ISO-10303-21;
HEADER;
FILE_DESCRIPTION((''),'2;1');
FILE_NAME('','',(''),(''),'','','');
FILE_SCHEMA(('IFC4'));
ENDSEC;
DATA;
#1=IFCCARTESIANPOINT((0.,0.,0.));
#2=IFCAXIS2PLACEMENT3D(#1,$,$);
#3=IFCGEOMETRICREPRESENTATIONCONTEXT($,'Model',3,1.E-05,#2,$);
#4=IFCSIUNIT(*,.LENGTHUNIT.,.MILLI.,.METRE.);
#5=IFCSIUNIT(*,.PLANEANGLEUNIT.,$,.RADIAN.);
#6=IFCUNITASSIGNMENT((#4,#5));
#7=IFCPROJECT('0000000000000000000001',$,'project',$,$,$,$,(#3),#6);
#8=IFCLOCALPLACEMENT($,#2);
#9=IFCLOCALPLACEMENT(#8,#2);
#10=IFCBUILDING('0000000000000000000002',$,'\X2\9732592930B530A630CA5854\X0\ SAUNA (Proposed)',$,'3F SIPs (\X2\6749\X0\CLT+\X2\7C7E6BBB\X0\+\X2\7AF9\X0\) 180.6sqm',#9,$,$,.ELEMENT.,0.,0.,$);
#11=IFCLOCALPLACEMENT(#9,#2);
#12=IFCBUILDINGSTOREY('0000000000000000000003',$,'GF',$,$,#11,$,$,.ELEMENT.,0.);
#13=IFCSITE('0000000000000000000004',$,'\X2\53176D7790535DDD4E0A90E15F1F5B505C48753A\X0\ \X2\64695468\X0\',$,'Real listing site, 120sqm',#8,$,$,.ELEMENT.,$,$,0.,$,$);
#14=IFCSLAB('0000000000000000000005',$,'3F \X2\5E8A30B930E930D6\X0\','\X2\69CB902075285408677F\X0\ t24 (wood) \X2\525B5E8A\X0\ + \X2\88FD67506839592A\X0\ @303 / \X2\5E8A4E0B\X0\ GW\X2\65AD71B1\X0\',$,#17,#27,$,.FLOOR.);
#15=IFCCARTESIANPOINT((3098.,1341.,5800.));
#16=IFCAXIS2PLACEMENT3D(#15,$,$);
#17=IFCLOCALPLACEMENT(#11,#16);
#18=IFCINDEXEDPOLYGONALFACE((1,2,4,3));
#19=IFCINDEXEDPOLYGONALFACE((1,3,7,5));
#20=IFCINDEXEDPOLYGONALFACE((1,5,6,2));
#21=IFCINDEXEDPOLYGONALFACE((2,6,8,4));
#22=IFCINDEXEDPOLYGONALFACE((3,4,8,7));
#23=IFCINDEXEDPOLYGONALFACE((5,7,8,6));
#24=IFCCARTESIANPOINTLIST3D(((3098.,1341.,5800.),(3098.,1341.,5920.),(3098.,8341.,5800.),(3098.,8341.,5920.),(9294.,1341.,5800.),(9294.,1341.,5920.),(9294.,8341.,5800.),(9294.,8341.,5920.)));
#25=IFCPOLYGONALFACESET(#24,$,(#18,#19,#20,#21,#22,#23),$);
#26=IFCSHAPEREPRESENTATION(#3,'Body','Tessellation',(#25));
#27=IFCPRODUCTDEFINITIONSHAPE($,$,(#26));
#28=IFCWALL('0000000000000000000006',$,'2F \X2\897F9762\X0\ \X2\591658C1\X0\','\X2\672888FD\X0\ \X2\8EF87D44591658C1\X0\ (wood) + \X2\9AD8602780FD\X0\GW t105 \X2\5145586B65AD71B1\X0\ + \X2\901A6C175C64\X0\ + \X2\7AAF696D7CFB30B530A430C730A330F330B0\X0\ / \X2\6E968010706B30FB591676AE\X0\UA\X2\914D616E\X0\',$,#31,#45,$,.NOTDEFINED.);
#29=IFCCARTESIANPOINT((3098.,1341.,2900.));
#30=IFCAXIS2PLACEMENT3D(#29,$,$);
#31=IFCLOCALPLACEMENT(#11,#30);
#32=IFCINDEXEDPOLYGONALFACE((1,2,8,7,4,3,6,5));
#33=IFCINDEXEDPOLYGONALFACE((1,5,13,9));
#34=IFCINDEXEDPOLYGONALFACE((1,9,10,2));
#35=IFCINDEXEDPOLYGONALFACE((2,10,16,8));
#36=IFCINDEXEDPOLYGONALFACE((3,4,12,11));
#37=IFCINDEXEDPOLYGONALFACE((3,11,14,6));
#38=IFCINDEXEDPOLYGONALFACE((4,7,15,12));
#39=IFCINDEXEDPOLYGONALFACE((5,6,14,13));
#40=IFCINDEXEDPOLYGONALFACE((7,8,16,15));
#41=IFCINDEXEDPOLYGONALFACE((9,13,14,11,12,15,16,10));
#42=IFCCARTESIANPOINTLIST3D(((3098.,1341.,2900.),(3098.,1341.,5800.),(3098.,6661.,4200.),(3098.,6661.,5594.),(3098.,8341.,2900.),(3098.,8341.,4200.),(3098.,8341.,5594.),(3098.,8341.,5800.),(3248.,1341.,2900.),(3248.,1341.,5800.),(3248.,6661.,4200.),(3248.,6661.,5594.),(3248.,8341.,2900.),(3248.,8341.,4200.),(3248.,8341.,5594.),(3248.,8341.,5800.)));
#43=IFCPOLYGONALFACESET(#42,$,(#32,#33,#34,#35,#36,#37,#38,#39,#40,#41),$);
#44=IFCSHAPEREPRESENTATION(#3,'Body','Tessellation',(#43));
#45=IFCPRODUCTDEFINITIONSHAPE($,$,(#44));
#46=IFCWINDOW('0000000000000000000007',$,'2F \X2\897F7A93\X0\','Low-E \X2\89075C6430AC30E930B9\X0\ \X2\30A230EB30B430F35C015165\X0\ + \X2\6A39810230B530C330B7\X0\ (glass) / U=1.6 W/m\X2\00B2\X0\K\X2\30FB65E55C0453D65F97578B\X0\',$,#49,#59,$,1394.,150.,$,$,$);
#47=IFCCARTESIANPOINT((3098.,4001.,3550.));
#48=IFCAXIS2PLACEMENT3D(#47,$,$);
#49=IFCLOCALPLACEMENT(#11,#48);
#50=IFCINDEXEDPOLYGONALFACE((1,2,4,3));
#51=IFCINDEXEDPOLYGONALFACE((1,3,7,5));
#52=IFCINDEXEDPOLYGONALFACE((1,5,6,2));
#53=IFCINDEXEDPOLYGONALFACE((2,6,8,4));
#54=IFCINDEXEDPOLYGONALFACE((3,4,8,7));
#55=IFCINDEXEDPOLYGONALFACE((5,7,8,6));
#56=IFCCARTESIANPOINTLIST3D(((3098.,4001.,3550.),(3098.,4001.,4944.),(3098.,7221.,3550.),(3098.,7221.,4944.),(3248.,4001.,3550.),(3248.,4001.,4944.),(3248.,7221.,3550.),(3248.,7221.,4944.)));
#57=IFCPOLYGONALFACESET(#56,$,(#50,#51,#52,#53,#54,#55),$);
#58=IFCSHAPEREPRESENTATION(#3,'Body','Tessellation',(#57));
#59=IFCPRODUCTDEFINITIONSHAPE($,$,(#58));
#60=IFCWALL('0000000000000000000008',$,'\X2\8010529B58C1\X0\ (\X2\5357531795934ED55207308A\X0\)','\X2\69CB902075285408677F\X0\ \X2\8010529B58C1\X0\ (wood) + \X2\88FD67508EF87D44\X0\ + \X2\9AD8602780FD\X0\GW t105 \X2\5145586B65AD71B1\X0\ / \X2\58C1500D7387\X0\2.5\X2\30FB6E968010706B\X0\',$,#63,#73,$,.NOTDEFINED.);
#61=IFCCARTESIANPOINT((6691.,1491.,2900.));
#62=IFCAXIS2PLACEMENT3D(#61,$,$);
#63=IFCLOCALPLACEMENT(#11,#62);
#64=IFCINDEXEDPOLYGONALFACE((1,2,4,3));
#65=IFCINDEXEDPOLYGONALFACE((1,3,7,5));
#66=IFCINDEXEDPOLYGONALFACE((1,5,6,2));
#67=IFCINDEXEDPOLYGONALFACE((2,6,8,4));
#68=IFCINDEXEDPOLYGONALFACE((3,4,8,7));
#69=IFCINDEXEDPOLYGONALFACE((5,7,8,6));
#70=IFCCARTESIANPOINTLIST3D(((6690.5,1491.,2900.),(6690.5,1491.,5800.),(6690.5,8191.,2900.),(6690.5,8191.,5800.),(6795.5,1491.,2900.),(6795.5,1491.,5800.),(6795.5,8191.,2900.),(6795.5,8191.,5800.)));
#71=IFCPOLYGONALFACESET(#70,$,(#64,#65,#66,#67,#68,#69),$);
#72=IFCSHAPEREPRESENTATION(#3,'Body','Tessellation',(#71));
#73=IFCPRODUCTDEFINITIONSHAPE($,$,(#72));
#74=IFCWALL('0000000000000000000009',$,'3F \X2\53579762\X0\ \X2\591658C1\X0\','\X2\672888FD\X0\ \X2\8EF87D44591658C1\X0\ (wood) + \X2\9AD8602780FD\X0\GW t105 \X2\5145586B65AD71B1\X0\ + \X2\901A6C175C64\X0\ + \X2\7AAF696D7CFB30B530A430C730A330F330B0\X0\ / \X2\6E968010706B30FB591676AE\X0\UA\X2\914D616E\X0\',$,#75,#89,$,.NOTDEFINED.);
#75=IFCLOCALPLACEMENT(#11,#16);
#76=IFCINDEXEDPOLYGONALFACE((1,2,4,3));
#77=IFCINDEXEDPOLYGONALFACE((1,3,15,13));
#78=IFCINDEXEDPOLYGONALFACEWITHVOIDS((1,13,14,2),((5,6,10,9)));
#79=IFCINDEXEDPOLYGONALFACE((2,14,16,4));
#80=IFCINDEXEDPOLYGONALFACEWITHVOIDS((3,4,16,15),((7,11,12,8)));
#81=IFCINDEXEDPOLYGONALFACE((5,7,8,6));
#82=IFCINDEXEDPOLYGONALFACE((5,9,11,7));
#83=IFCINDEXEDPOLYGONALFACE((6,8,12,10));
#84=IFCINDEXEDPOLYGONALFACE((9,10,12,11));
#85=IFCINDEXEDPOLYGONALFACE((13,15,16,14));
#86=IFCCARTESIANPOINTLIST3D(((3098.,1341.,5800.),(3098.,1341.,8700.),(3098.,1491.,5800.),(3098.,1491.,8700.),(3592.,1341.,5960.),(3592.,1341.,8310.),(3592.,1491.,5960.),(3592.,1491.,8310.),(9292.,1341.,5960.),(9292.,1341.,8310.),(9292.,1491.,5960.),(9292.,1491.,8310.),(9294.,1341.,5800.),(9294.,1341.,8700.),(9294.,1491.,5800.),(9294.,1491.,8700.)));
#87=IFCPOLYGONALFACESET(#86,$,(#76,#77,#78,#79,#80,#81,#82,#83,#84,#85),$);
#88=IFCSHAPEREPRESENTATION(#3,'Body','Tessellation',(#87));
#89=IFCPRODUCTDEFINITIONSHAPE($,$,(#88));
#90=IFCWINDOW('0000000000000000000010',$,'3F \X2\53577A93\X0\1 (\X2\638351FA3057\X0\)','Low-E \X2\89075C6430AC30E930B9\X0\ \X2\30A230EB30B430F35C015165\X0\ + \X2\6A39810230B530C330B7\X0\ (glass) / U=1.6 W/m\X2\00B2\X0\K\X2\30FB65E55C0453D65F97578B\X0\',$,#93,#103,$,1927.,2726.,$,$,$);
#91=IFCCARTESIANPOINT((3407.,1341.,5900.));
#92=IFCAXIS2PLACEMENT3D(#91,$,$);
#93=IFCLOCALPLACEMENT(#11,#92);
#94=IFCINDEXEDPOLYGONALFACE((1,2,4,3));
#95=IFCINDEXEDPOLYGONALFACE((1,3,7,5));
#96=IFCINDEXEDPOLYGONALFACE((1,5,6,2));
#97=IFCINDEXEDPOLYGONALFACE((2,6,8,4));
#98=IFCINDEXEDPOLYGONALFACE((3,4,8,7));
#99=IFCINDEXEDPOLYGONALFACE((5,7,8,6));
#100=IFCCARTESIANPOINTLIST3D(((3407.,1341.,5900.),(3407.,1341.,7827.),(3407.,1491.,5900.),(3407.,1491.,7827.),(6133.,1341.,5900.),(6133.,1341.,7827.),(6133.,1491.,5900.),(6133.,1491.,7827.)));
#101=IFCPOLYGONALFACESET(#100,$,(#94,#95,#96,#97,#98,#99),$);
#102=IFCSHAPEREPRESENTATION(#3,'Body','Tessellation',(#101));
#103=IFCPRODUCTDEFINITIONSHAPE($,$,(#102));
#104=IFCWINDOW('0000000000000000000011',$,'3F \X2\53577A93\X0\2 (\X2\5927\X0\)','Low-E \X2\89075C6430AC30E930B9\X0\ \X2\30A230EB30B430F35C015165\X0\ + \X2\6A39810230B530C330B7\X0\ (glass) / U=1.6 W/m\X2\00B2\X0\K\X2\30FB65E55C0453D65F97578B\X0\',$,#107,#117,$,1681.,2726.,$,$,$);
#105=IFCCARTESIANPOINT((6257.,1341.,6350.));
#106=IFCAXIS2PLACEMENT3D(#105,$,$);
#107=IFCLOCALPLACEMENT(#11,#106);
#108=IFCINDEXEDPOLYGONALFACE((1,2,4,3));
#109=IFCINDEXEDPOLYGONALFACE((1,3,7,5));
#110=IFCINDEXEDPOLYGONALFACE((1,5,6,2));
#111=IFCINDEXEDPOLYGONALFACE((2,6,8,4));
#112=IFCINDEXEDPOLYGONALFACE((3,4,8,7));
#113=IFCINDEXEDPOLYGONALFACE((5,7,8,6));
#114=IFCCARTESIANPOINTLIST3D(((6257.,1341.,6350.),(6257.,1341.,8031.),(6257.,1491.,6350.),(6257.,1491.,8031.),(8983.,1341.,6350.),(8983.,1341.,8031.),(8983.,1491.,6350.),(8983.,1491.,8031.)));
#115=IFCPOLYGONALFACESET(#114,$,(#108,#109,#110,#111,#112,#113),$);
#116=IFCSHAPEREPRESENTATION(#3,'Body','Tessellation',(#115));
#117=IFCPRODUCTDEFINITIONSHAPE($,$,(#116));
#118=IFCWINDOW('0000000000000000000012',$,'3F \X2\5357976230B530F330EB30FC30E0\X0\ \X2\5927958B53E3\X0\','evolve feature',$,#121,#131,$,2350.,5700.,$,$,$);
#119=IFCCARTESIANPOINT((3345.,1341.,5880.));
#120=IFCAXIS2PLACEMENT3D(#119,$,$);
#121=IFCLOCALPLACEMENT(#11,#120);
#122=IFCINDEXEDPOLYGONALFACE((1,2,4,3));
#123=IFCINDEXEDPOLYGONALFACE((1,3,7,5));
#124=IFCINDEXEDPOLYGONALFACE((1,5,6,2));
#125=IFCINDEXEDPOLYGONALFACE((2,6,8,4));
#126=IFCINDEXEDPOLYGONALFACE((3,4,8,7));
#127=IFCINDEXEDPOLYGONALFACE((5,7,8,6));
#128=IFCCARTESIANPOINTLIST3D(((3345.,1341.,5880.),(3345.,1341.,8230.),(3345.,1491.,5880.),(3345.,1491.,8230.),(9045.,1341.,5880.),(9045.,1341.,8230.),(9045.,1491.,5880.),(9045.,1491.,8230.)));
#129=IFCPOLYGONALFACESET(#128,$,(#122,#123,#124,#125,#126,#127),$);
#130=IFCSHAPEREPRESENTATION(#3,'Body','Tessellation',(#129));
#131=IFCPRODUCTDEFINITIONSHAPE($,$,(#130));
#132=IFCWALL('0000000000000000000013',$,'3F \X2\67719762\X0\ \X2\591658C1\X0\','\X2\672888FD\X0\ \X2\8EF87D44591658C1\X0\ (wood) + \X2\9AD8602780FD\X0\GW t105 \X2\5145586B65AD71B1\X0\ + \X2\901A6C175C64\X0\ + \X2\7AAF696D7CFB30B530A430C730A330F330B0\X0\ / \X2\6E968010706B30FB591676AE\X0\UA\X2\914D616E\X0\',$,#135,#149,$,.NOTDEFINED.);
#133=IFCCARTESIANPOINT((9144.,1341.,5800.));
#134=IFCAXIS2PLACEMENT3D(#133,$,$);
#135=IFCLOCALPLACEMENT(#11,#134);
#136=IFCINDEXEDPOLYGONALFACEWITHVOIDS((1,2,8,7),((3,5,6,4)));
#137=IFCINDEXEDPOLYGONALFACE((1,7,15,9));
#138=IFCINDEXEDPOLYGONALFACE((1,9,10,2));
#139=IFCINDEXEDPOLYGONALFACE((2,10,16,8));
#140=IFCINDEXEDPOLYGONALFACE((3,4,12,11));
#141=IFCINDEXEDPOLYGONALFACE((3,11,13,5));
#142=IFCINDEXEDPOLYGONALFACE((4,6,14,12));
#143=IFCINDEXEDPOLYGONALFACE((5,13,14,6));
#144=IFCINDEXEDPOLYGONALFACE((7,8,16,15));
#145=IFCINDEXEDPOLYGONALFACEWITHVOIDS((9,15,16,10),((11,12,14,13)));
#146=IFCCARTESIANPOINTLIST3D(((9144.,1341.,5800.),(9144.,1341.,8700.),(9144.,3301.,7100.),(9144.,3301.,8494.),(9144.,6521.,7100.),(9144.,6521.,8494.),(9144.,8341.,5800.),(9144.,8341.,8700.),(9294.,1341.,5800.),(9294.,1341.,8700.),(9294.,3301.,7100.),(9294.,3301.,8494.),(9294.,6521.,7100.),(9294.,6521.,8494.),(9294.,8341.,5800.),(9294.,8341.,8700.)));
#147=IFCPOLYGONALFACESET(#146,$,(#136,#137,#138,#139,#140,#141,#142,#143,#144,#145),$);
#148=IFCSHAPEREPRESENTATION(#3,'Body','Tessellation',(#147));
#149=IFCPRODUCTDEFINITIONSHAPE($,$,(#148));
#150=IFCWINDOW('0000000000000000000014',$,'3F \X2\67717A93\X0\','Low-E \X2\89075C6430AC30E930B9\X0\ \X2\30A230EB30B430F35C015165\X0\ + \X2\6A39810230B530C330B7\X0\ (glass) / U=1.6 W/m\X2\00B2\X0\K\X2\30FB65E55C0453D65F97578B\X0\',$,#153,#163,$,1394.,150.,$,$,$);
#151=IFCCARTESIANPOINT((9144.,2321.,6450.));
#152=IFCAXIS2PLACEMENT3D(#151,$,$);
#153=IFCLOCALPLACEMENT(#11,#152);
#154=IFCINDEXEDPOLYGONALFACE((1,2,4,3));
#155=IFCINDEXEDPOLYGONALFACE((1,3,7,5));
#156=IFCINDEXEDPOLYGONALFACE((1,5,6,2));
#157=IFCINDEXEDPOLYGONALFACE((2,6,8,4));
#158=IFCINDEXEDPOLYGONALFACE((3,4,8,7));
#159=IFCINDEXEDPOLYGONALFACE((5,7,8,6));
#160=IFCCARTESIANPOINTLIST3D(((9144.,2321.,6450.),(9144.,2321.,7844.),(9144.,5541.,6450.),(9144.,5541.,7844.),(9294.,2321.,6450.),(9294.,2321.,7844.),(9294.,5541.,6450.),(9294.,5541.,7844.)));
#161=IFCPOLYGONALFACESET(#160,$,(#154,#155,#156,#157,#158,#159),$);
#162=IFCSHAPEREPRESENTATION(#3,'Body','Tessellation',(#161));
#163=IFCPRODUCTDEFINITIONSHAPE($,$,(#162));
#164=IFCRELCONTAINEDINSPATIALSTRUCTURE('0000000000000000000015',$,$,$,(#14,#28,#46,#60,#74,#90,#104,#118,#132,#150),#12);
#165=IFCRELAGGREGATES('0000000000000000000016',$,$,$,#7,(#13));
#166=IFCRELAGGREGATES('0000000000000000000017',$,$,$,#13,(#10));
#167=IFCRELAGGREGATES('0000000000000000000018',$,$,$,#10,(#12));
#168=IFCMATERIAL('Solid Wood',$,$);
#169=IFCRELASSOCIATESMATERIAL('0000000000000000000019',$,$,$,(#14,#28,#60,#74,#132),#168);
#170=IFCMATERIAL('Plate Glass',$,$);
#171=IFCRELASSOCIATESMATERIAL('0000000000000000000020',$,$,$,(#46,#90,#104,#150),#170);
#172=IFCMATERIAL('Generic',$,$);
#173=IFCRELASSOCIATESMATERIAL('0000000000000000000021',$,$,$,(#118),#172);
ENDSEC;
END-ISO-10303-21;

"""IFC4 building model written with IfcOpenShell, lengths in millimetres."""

from ifc_helpers import new_model, si_unit, frame, frame_2d, origin, place, context, project, spatial, rectangle, extrude, material, element, fill, save


model = new_model("IFC4")

# Units and contexts
model_context = context("Model", 3, precision=1e-05, world=origin())
ifc_project = project(units=[si_unit("LENGTHUNIT", "METRE", prefix="MILLI"), si_unit("PLANEANGLEUNIT", "RADIAN")], contexts=[model_context])

# Site, building, storey
site_placement = place(None, origin())
site = spatial("IfcSite", under=ifc_project, at=site_placement, Name="北海道川上郡弟子屈町 摩周", ObjectType="Real listing site, 120sqm", CompositionType="ELEMENT", RefElevation=0.0)
building_placement = place(site_placement, origin())
building = spatial("IfcBuilding", under=site, at=building_placement, Name="露天サウナ塔 SAUNA (Proposed)", ObjectType="3F SIPs (杉CLT+籾殻+竹) 180.6sqm", CompositionType="ELEMENT", ElevationOfRefHeight=0.0, ElevationOfTerrain=0.0)
storey_placement = place(building_placement, origin())
storey = spatial("IfcBuildingStorey", under=building, at=storey_placement, Name="GF", CompositionType="ELEMENT", Elevation=0.0)

# Slab
ifc_material_1 = material(Name="Solid Wood")
slab_placement = place(storey_placement, frame((3098.0, 1341.0, 5800.0)))
element("IfcSlab", 1, at=slab_placement, inside=storey, material=ifc_material_1, Name="3F 床スラブ", Description="構造用合板 t24 (wood) 剛床 + 製材根太 @303 / 床下 GW断熱", PredefinedType="FLOOR", context=model_context, shape_type="SweptSolid", body=[
    extrude(rectangle(XDim=6196.0, YDim=7000.0, at=frame_2d((3098.0, 3500.0))), frame((3098.0, 1341.0, 5800.0)), (0.0, 0.0, 1.0), 120.0),
])

# Wall, opening, window
wall_1_placement = place(storey_placement, frame((3098.0, 1341.0, 2900.0)))
wall_1 = element("IfcWall", 2, at=wall_1_placement, inside=storey, material=ifc_material_1, Name="2F 西面 外壁", Description="木製 軸組外壁 (wood) + 高性能GW t105 充填断熱 + 通気層 + 窯業系サイディング / 準耐火・外皮UA配慮", PredefinedType="NOTDEFINED", context=model_context, shape_type="SweptSolid", body=[
    extrude(rectangle(XDim=150.0, YDim=7000.0, at=frame_2d((75.0, 3500.0))), frame((3098.0, 1341.0, 2900.0)), (0.0, 0.0, 1.0), 2900.0),
])
opening_1_placement = place(storey_placement, frame((3098.0, 4001.0, 3550.0)))
opening_1 = element("IfcOpeningElement", 3, at=opening_1_placement, cuts=wall_1, PredefinedType="NOTDEFINED", context=model_context, shape_type="SweptSolid", body=[
    extrude(rectangle(XDim=150.0, YDim=3220.0, at=frame_2d((75.0, 1610.0))), frame((3098.0, 4001.0, 3550.0)), (0.0, 0.0, 1.0), 1394.0),
])
ifc_material_2 = material(Name="Plate Glass")
window_1_placement = place(storey_placement, frame((3098.0, 4001.0, 3550.0)))
window_1 = element("IfcWindow", 4, at=window_1_placement, inside=storey, material=ifc_material_2, Name="2F 西窓", Description="Low-E 複層ガラス アルゴン封入 + 樹脂サッシ (glass) / U=1.6 W/m²K・日射取得型", OverallHeight=1394.0, OverallWidth=150.0, context=model_context, shape_type="SweptSolid", body=[
    extrude(rectangle(XDim=150.0, YDim=3220.0, at=frame_2d((75.0, 1610.0))), frame((3098.0, 4001.0, 3550.0)), (0.0, 0.0, 1.0), 1394.0),
])
fill(opening_1, window_1)

# Wall
wall_2_placement = place(storey_placement, frame((6691.0, 1491.0, 2900.0)))
element("IfcWall", 5, at=wall_2_placement, inside=storey, material=ifc_material_1, Name="耐力壁 (南北間仕切り)", Description="構造用合板 耐力壁 (wood) + 製材軸組 + 高性能GW t105 充填断熱 / 壁倍率2.5・準耐火", PredefinedType="NOTDEFINED", context=model_context, shape_type="SweptSolid", body=[
    extrude(rectangle(XDim=105.0, YDim=6700.0, at=frame_2d((52.0, 3350.0))), frame((6691.0, 1491.0, 2900.0)), (0.0, 0.0, 1.0), 2900.0),
])

# Wall, openings, windows
wall_3_placement = place(storey_placement, frame((3098.0, 1341.0, 5800.0)))
wall_3 = element("IfcWall", 6, at=wall_3_placement, inside=storey, material=ifc_material_1, Name="3F 南面 外壁", Description="木製 軸組外壁 (wood) + 高性能GW t105 充填断熱 + 通気層 + 窯業系サイディング / 準耐火・外皮UA配慮", PredefinedType="NOTDEFINED", context=model_context, shape_type="SweptSolid", body=[
    extrude(rectangle(XDim=6196.0, YDim=150.0, at=frame_2d((3098.0, 75.0))), frame((3098.0, 1341.0, 5800.0)), (0.0, 0.0, 1.0), 2900.0),
])
opening_2_placement = place(storey_placement, frame((3407.0, 1341.0, 5900.0)))
opening_2 = element("IfcOpeningElement", 7, at=opening_2_placement, cuts=wall_3, PredefinedType="NOTDEFINED", context=model_context, shape_type="SweptSolid", body=[
    extrude(rectangle(XDim=2726.0, YDim=150.0, at=frame_2d((1363.0, 75.0))), frame((3407.0, 1341.0, 5900.0)), (0.0, 0.0, 1.0), 1927.0),
])
opening_3_placement = place(storey_placement, frame((6257.0, 1341.0, 6350.0)))
opening_3 = element("IfcOpeningElement", 8, at=opening_3_placement, cuts=wall_3, PredefinedType="NOTDEFINED", context=model_context, shape_type="SweptSolid", body=[
    extrude(rectangle(XDim=2726.0, YDim=150.0, at=frame_2d((1363.0, 75.0))), frame((6257.0, 1341.0, 6350.0)), (0.0, 0.0, 1.0), 1681.0),
])
opening_4_placement = place(storey_placement, frame((3345.0, 1341.0, 5880.0)))
opening_4 = element("IfcOpeningElement", 9, at=opening_4_placement, cuts=wall_3, PredefinedType="NOTDEFINED", context=model_context, shape_type="SweptSolid", body=[
    extrude(rectangle(XDim=5700.0, YDim=150.0, at=frame_2d((2850.0, 75.0))), frame((3345.0, 1341.0, 5880.0)), (0.0, 0.0, 1.0), 2350.0),
])
window_2_placement = place(storey_placement, frame((3407.0, 1341.0, 5900.0)))
window_2 = element("IfcWindow", 10, at=window_2_placement, inside=storey, material=ifc_material_2, Name="3F 南窓1 (掃出し)", Description="Low-E 複層ガラス アルゴン封入 + 樹脂サッシ (glass) / U=1.6 W/m²K・日射取得型", OverallHeight=1927.0, OverallWidth=2726.0, context=model_context, shape_type="SweptSolid", body=[
    extrude(rectangle(XDim=2726.0, YDim=150.0, at=frame_2d((1363.0, 75.0))), frame((3407.0, 1341.0, 5900.0)), (0.0, 0.0, 1.0), 1927.0),
])
fill(opening_2, window_2)
window_3_placement = place(storey_placement, frame((6257.0, 1341.0, 6350.0)))
window_3 = element("IfcWindow", 11, at=window_3_placement, inside=storey, material=ifc_material_2, Name="3F 南窓2 (大)", Description="Low-E 複層ガラス アルゴン封入 + 樹脂サッシ (glass) / U=1.6 W/m²K・日射取得型", OverallHeight=1681.0, OverallWidth=2726.0, context=model_context, shape_type="SweptSolid", body=[
    extrude(rectangle(XDim=2726.0, YDim=150.0, at=frame_2d((1363.0, 75.0))), frame((6257.0, 1341.0, 6350.0)), (0.0, 0.0, 1.0), 1681.0),
])
fill(opening_3, window_3)
ifc_material_3 = material(Name="Generic")
window_4_placement = place(storey_placement, frame((3345.0, 1341.0, 5880.0)))
window_4 = element("IfcWindow", 12, at=window_4_placement, inside=storey, material=ifc_material_3, Name="3F 南面サンルーム 大開口", Description="evolve feature", OverallHeight=2350.0, OverallWidth=5700.0, context=model_context, shape_type="SweptSolid", body=[
    extrude(rectangle(XDim=5700.0, YDim=150.0, at=frame_2d((2850.0, 75.0))), frame((3345.0, 1341.0, 5880.0)), (0.0, 0.0, 1.0), 2350.0),
])
fill(opening_4, window_4)

# Wall, opening, window
wall_4_placement = place(storey_placement, frame((9144.0, 1341.0, 5800.0)))
wall_4 = element("IfcWall", 13, at=wall_4_placement, inside=storey, material=ifc_material_1, Name="3F 東面 外壁", Description="木製 軸組外壁 (wood) + 高性能GW t105 充填断熱 + 通気層 + 窯業系サイディング / 準耐火・外皮UA配慮", PredefinedType="NOTDEFINED", context=model_context, shape_type="SweptSolid", body=[
    extrude(rectangle(XDim=150.0, YDim=7000.0, at=frame_2d((75.0, 3500.0))), frame((9144.0, 1341.0, 5800.0)), (0.0, 0.0, 1.0), 2900.0),
])
opening_5_placement = place(storey_placement, frame((9144.0, 2321.0, 6450.0)))
opening_5 = element("IfcOpeningElement", 14, at=opening_5_placement, cuts=wall_4, PredefinedType="NOTDEFINED", context=model_context, shape_type="SweptSolid", body=[
    extrude(rectangle(XDim=150.0, YDim=3220.0, at=frame_2d((75.0, 1610.0))), frame((9144.0, 2321.0, 6450.0)), (0.0, 0.0, 1.0), 1394.0),
])
window_5_placement = place(storey_placement, frame((9144.0, 2321.0, 6450.0)))
window_5 = element("IfcWindow", 15, at=window_5_placement, inside=storey, material=ifc_material_2, Name="3F 東窓", Description="Low-E 複層ガラス アルゴン封入 + 樹脂サッシ (glass) / U=1.6 W/m²K・日射取得型", OverallHeight=1394.0, OverallWidth=150.0, context=model_context, shape_type="SweptSolid", body=[
    extrude(rectangle(XDim=150.0, YDim=3220.0, at=frame_2d((75.0, 1610.0))), frame((9144.0, 2321.0, 6450.0)), (0.0, 0.0, 1.0), 1394.0),
])
fill(opening_5, window_5)

save(model, "model.ifc")
